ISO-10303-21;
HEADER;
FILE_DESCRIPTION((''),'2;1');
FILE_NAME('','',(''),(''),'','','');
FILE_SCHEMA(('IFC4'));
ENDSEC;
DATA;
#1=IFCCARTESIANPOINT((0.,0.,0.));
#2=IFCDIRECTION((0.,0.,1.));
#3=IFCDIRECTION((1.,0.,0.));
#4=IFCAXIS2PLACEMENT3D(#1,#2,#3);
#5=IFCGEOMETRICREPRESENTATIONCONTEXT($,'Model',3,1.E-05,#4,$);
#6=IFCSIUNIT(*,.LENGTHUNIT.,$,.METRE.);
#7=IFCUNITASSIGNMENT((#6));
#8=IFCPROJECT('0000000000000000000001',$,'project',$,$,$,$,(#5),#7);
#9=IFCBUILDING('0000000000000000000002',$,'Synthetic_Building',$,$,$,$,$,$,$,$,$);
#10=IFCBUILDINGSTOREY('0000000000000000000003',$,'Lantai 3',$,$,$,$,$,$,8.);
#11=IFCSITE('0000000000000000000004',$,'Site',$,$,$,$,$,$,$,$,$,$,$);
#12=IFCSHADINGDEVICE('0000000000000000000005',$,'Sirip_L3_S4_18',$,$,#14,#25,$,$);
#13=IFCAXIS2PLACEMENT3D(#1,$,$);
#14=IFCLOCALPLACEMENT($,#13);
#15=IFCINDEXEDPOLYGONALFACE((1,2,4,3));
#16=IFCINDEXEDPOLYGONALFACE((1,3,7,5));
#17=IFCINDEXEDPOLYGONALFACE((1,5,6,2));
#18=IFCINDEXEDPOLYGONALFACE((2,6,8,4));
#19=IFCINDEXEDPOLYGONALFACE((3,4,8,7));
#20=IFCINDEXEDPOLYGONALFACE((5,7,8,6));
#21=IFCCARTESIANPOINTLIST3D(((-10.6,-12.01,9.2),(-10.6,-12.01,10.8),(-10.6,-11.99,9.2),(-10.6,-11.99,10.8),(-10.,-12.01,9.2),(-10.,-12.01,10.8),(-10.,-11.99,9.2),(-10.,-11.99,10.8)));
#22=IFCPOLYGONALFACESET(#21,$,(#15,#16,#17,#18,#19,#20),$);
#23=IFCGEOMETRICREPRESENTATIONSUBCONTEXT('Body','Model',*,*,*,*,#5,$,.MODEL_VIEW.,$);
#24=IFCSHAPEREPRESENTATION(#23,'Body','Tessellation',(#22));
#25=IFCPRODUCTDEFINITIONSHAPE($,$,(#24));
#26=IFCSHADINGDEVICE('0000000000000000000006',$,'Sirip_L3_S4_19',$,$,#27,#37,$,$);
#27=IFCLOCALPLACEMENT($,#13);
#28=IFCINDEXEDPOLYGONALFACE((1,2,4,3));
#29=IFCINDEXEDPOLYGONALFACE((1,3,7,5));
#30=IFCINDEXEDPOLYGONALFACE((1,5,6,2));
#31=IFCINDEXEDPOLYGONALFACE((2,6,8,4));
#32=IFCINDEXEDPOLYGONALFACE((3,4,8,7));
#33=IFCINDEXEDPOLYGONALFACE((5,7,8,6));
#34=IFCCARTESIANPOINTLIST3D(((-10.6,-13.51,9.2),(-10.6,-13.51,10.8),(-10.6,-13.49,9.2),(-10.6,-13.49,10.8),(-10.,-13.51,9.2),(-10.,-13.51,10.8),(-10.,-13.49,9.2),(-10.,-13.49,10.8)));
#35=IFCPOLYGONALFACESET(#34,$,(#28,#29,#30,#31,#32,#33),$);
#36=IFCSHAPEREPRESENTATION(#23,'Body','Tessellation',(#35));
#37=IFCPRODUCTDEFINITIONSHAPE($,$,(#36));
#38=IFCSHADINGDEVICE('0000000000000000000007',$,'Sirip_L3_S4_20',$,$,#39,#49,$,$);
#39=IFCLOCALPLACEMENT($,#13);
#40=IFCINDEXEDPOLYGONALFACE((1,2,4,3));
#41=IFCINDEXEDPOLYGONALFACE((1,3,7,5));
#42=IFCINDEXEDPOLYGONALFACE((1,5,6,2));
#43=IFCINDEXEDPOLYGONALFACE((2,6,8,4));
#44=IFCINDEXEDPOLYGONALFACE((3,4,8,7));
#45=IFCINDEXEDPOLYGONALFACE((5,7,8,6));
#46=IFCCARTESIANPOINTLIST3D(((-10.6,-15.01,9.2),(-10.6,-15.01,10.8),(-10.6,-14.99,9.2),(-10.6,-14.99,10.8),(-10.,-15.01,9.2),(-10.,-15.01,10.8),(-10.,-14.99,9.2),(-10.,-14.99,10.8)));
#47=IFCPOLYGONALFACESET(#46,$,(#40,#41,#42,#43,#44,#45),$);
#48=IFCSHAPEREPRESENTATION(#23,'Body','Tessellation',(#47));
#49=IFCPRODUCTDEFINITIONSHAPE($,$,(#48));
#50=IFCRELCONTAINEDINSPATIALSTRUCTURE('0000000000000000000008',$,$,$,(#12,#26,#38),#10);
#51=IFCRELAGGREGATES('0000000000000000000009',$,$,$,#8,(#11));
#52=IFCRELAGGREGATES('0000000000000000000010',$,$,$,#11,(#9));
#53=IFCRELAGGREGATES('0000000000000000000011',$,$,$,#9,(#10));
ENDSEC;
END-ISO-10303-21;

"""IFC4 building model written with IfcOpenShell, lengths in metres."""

from ifc_helpers import new_model, si_unit, frame, origin_with_axes, place, context, subcontext, project, spatial, polyline, outline, extrude, element, save


model = new_model("IFC4")

# Units and contexts
model_context = context("Model", 3, precision=1e-05, world=origin_with_axes())
body_context = subcontext(model_context, "Body", "Model", "MODEL_VIEW")
ifc_project = project(units=[si_unit("LENGTHUNIT", "METRE")], contexts=[model_context])

# Site, building, storey
site = spatial("IfcSite", under=ifc_project, Name="Site")
building = spatial("IfcBuilding", under=site, Name="Synthetic_Building")
storey = spatial("IfcBuildingStorey", under=building, Name="Lantai 3", Elevation=8.0)

# Shading devices
shading_device_1_placement = place(None, origin_with_axes())
element("IfcShadingDevice", 1, at=shading_device_1_placement, inside=storey, Name="Sirip_L3_S4_18", context=body_context, shape_type="SweptSolid", body=[
    extrude(outline(polyline([(-10.0, -11.99), (-10.0, -12.01), (-10.6, -12.01), (-10.6, -11.99), (-10.0, -11.99)])), frame((0.0, 0.0, 9.2), z_axis=(0.0, 0.0, 1.0), x_axis=(1.0, 0.0, 0.0)), (0.0, 0.0, 1.0), 1.6),
])
shading_device_2_placement = place(None, origin_with_axes())
element("IfcShadingDevice", 2, at=shading_device_2_placement, inside=storey, Name="Sirip_L3_S4_19", context=body_context, shape_type="SweptSolid", body=[
    extrude(outline(polyline([(-10.0, -13.49), (-10.0, -13.51), (-10.6, -13.51), (-10.6, -13.49), (-10.0, -13.49)])), frame((0.0, 0.0, 9.2), z_axis=(0.0, 0.0, 1.0), x_axis=(1.0, 0.0, 0.0)), (0.0, 0.0, 1.0), 1.6),
])
shading_device_3_placement = place(None, origin_with_axes())
element("IfcShadingDevice", 3, at=shading_device_3_placement, inside=storey, Name="Sirip_L3_S4_20", context=body_context, shape_type="SweptSolid", body=[
    extrude(outline(polyline([(-10.0, -14.99), (-10.0, -15.01), (-10.6, -15.01), (-10.6, -14.99), (-10.0, -14.99)])), frame((0.0, 0.0, 9.2), z_axis=(0.0, 0.0, 1.0), x_axis=(1.0, 0.0, 0.0)), (0.0, 0.0, 1.0), 1.6),
])

save(model, "model.ifc")
